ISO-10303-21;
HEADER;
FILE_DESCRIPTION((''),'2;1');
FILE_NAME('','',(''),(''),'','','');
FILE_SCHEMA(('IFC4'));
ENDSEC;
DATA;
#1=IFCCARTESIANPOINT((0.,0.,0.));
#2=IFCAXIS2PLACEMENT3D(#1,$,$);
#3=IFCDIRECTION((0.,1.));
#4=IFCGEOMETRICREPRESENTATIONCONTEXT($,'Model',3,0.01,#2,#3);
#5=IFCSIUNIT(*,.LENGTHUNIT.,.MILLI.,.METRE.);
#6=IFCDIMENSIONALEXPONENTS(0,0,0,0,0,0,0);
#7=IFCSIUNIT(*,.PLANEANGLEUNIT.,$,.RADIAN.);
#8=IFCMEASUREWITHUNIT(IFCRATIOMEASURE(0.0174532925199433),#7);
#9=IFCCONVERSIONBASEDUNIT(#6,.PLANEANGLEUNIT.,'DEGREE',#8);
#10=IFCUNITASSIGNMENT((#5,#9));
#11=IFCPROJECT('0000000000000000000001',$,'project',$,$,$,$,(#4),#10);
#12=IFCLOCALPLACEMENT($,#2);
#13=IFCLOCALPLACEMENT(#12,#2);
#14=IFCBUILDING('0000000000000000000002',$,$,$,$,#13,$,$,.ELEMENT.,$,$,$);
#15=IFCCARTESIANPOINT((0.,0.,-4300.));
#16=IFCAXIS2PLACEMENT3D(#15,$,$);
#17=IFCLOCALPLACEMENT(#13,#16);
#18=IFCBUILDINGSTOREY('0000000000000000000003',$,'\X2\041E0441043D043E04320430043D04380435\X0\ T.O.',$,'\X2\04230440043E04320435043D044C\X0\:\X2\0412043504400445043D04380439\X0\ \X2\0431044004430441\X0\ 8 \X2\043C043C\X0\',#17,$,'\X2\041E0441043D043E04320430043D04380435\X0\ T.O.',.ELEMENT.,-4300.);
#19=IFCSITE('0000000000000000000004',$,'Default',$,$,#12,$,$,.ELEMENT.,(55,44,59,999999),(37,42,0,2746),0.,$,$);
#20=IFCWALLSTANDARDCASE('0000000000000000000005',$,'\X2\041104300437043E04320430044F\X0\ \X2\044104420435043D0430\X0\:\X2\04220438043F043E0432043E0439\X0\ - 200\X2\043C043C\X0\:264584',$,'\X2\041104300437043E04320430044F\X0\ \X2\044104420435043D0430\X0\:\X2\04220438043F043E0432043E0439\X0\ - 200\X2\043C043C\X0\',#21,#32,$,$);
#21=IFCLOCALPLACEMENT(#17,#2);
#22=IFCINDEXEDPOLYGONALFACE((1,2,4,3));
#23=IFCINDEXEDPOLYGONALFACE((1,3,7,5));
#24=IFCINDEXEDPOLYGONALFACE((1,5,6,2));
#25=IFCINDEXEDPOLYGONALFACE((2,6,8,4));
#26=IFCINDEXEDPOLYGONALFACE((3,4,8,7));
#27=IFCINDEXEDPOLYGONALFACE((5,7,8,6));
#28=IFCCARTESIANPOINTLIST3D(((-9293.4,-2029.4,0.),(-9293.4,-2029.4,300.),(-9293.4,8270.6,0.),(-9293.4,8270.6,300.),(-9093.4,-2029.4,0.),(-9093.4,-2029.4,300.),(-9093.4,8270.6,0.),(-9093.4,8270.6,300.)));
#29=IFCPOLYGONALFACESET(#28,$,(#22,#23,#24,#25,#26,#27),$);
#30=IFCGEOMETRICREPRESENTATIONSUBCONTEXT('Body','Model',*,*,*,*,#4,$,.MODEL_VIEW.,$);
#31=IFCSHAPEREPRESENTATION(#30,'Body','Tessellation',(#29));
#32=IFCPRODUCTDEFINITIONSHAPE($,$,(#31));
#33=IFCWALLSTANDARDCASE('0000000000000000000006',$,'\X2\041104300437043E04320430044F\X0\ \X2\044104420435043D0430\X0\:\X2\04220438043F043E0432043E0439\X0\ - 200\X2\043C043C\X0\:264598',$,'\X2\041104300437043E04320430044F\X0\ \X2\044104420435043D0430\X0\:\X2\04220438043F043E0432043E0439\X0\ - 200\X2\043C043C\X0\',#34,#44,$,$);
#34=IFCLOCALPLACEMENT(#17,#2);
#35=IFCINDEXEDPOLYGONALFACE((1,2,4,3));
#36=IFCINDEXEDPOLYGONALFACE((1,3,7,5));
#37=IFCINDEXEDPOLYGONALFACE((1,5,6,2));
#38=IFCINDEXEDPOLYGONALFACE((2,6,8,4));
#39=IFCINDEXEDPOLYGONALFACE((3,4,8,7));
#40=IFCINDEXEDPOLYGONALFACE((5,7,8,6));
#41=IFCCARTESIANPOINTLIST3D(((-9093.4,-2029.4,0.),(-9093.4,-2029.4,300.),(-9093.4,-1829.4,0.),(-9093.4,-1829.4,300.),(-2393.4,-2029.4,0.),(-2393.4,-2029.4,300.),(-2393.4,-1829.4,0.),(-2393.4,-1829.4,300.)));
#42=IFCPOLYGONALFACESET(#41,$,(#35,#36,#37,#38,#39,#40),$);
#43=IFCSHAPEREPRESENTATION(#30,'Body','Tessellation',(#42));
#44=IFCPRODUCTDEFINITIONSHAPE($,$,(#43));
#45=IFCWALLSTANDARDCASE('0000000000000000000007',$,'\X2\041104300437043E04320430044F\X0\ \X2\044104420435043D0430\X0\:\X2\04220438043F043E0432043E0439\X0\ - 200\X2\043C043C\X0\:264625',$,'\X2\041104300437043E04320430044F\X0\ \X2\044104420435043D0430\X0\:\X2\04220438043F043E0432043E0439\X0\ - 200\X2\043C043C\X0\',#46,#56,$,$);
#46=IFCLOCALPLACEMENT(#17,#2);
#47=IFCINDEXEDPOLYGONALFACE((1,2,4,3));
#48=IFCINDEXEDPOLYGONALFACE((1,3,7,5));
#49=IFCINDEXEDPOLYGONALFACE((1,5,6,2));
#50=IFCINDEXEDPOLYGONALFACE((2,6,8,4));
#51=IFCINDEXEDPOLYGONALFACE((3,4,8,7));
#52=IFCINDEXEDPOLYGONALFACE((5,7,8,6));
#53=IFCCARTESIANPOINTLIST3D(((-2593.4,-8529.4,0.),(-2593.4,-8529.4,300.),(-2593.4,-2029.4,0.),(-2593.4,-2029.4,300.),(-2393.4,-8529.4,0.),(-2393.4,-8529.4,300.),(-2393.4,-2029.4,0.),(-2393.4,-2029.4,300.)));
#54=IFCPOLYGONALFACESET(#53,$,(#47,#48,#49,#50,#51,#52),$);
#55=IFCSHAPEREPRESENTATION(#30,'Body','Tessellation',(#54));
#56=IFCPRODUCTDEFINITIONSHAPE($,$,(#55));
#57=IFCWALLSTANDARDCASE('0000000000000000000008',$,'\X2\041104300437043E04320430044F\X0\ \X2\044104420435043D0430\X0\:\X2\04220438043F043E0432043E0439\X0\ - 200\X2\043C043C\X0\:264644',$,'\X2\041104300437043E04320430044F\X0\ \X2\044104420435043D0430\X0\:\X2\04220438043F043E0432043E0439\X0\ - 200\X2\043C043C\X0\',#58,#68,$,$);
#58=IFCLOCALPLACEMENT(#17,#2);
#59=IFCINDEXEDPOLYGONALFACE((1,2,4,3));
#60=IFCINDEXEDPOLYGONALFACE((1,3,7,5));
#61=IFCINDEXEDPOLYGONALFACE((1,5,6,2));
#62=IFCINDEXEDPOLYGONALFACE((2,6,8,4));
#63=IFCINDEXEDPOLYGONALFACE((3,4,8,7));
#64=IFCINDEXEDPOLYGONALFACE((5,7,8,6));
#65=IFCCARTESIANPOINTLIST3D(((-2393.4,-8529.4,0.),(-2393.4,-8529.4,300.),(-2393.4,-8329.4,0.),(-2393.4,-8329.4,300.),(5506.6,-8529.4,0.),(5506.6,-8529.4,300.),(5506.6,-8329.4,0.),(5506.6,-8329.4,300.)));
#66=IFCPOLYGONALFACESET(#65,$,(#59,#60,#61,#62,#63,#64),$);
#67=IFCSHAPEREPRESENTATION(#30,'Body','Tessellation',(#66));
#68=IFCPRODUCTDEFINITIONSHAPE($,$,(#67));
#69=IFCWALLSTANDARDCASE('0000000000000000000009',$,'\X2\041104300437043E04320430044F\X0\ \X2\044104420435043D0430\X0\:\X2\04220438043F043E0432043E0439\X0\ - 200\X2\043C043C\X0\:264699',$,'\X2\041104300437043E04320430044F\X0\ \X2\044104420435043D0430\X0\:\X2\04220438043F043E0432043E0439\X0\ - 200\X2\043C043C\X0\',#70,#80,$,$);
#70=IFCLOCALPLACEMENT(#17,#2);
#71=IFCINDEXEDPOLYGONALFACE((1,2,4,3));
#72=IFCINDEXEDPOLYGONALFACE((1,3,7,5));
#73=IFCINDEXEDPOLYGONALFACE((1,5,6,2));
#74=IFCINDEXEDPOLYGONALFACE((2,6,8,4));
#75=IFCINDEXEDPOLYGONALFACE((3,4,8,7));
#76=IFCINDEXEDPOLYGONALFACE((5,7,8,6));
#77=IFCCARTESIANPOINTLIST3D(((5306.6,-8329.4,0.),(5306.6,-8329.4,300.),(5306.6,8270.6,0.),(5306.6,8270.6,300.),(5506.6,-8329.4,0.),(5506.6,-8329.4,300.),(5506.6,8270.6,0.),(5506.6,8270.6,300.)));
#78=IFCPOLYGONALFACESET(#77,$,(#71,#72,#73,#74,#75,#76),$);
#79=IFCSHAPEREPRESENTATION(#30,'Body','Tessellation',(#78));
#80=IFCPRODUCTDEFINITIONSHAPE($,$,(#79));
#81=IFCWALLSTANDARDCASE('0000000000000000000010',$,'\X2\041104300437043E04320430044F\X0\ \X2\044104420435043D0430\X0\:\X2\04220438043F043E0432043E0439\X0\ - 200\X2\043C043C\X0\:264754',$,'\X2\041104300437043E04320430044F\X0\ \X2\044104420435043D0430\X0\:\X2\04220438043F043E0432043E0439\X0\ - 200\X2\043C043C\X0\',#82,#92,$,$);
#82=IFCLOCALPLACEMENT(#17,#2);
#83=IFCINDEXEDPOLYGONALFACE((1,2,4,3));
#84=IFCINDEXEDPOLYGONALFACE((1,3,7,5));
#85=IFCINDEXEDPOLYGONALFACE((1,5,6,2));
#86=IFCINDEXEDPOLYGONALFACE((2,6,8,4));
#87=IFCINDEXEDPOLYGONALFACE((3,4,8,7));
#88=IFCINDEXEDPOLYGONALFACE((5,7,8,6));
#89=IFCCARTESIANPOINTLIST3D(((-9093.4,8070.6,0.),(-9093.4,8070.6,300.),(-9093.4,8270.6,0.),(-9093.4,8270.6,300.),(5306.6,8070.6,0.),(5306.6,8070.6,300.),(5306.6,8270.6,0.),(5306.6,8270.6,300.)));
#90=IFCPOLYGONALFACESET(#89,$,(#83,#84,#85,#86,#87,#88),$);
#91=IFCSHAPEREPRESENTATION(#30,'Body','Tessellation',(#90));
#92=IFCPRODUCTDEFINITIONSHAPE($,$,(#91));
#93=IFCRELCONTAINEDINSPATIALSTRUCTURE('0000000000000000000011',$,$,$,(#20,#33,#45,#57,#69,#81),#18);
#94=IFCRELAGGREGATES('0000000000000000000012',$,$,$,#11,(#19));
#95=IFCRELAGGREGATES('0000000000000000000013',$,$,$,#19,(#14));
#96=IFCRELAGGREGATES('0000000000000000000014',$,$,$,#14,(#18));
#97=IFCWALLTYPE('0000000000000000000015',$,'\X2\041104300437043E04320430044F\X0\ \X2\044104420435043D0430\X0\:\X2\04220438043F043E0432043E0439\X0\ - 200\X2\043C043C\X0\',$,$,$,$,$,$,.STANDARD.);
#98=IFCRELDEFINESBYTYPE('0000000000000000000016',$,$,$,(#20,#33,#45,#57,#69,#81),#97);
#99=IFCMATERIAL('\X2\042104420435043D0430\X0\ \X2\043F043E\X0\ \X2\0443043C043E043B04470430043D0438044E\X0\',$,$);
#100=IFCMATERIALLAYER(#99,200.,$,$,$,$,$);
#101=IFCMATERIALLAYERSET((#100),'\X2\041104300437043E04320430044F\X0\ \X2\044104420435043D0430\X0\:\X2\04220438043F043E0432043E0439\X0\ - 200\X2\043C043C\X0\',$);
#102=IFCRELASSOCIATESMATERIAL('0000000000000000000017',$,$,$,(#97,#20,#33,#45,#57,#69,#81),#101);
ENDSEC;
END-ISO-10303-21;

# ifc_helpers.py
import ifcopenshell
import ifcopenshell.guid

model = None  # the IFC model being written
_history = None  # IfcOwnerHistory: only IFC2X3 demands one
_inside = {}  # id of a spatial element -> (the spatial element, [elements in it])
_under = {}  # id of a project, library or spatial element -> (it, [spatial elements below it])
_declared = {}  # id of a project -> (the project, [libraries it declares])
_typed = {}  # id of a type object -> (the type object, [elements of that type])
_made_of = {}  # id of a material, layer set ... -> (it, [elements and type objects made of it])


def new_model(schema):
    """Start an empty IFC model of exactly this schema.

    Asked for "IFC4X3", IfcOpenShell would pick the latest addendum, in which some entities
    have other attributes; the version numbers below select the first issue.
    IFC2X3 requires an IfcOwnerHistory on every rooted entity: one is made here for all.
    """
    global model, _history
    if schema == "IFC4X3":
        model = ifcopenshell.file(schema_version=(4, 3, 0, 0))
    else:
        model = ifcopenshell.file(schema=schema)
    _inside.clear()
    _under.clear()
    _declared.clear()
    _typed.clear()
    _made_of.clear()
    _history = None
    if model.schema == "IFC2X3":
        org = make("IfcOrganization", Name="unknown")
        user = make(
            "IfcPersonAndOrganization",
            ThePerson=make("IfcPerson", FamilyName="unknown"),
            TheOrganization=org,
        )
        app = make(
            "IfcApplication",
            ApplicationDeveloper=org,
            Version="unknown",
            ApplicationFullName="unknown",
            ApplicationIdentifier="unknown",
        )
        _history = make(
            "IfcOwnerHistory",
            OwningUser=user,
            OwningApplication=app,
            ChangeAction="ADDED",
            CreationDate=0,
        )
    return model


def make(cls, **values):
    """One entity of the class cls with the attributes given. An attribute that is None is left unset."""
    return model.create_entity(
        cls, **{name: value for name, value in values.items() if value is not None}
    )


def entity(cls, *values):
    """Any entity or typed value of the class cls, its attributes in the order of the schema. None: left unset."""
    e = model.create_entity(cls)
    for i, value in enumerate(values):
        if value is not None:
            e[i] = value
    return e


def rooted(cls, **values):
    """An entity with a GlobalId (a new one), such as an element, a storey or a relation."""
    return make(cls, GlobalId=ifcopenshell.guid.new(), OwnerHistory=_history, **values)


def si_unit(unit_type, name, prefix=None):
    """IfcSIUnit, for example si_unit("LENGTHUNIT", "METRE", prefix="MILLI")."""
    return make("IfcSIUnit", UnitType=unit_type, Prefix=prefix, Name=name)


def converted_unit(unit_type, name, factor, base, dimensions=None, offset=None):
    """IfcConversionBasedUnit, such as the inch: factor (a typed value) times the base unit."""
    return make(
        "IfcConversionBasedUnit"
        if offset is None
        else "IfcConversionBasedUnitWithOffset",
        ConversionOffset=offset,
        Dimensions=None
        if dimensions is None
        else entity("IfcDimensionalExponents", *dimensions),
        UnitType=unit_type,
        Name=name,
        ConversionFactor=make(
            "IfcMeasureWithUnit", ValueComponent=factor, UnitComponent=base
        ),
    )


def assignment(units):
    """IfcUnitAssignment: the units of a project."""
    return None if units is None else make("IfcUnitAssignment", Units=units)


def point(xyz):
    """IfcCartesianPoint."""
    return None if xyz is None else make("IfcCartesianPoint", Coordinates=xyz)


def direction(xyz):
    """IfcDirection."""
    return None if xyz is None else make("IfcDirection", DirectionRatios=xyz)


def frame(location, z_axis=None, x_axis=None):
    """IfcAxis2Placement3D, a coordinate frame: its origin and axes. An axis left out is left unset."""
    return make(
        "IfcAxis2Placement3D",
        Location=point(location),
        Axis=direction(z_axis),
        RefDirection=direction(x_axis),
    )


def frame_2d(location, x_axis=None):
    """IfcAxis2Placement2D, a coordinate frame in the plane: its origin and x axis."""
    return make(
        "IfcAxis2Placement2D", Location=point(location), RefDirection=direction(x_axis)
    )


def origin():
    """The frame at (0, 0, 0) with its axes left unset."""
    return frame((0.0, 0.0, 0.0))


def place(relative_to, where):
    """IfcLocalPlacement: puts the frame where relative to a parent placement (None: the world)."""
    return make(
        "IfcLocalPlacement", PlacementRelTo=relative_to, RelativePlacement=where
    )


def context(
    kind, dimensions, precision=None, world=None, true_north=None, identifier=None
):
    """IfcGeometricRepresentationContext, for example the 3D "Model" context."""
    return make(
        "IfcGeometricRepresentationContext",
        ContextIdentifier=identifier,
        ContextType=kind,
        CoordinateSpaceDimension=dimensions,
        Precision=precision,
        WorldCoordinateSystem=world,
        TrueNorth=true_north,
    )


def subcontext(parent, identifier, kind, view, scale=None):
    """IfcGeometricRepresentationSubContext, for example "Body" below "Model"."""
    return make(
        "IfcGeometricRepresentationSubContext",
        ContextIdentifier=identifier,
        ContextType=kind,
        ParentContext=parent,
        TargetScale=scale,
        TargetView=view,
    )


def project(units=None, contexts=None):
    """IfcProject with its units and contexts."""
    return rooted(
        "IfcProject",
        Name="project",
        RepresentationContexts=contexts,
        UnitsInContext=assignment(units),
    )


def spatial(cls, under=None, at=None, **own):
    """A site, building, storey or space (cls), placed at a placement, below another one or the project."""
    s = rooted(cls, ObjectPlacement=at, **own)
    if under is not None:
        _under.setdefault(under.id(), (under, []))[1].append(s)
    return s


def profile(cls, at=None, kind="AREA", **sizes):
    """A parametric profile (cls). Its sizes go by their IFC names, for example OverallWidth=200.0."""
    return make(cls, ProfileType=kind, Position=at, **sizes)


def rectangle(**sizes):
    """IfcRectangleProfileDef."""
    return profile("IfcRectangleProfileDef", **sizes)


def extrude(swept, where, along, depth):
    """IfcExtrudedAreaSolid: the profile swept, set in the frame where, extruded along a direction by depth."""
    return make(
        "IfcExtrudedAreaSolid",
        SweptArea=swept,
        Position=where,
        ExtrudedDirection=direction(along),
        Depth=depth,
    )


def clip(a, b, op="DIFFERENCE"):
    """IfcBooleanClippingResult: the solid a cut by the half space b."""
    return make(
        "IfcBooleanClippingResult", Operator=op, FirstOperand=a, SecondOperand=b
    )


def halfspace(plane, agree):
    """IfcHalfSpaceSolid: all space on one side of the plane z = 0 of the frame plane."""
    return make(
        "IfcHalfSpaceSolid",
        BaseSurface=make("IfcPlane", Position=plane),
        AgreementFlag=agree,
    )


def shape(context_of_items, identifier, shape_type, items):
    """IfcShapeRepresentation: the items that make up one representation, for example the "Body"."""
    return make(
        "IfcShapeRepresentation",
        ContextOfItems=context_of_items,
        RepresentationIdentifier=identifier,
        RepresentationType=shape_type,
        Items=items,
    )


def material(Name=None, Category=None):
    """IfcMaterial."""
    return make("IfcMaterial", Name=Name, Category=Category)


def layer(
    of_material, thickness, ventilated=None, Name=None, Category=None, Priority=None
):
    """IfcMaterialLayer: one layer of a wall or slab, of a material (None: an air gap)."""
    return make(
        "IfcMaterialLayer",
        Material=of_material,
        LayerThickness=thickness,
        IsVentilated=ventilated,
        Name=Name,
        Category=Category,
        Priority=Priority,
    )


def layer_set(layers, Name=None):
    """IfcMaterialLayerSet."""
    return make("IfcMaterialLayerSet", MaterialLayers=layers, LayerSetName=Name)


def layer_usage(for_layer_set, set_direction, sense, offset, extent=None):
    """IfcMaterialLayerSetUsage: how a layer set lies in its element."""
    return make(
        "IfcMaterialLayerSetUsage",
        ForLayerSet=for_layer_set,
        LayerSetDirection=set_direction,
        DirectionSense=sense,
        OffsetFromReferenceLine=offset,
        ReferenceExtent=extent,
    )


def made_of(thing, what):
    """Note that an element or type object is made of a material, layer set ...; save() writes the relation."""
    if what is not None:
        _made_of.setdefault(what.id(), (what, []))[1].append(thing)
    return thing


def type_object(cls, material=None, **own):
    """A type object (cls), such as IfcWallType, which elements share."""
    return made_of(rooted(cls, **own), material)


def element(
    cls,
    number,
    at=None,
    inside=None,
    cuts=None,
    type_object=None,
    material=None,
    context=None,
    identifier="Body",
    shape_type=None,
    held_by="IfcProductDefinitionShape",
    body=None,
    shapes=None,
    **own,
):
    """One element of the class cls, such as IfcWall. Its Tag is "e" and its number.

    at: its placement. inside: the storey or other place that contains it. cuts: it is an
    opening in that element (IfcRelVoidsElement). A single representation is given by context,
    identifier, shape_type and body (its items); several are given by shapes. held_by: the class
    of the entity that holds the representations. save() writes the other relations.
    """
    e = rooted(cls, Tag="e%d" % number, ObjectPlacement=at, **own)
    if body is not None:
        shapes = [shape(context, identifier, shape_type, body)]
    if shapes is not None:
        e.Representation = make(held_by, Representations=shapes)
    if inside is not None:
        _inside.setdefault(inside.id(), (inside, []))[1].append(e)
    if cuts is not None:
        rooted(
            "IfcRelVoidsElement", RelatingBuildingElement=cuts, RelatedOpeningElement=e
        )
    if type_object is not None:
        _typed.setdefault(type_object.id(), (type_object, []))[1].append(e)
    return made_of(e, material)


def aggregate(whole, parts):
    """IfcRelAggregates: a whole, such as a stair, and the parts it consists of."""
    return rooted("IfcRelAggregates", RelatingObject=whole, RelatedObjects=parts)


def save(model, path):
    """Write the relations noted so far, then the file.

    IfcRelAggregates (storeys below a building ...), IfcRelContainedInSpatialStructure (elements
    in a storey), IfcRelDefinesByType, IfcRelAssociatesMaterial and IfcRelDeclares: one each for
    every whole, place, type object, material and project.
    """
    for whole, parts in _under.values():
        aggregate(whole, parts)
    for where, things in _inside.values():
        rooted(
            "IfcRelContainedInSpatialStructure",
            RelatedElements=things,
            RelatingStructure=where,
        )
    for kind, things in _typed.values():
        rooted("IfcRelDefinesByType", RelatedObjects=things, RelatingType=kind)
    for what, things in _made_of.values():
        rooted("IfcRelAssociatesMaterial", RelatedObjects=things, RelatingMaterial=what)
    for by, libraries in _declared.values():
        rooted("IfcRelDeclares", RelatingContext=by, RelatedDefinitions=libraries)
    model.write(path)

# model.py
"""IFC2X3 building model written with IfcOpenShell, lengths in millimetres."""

from ifc_helpers import new_model, entity, si_unit, converted_unit, direction, frame, frame_2d, origin, place, context, subcontext, project, spatial, rectangle, extrude, clip, halfspace, material, layer, layer_set, layer_usage, type_object, element, save


model = new_model("IFC2X3")

# Units and contexts
model_context = context("Model", 3, precision=0.01, world=origin(), true_north=direction((0.0, 1.0)))
body_context = subcontext(model_context, "Body", "Model", "MODEL_VIEW")
ifc_project = project(units=[si_unit("LENGTHUNIT", "METRE", prefix="MILLI"), converted_unit("PLANEANGLEUNIT", "DEGREE", entity("IfcRatioMeasure", 0.0174532925199433), si_unit("PLANEANGLEUNIT", "RADIAN"), dimensions=[0, 0, 0, 0, 0, 0, 0])], contexts=[model_context])

# Site, building, storey
site_placement = place(None, origin())
site = spatial("IfcSite", under=ifc_project, at=site_placement, Name="Default", CompositionType="ELEMENT", RefLatitude=(55, 44, 59, 999999), RefLongitude=(37, 42, 0, 2746), RefElevation=0.0)
building_placement = place(site_placement, origin())
building = spatial("IfcBuilding", under=site, at=building_placement, CompositionType="ELEMENT")
storey_placement = place(building_placement, frame((0.0, 0.0, -4300.0)))
storey = spatial("IfcBuildingStorey", under=building, at=storey_placement, Name="Основание T.O.", ObjectType="Уровень:Верхний брус 8 мм", LongName="Основание T.O.", CompositionType="ELEMENT", Elevation=-4300.0)

# Walls
ifc_material = material(Name="Стена по умолчанию")
ifc_layer = layer(ifc_material, 200.0)
ifc_layer_set = layer_set([ifc_layer], Name="Базовая стена:Типовой - 200мм")
ifc_layer_usage_1 = layer_usage(ifc_layer_set, "AXIS2", "NEGATIVE", 100.0)
wall_type = type_object("IfcWallType", Name="Базовая стена:Типовой - 200мм", PredefinedType="STANDARD", material=ifc_layer_set)
wall_1_placement = place(storey_placement, frame((-9193.4, 8270.6, 0.0), z_axis=(0.0, 0.0, 1.0), x_axis=(0.0, -1.0, 0.0)))
element("IfcWallStandardCase", 1, at=wall_1_placement, inside=storey, type_object=wall_type, material=ifc_layer_usage_1, Name="Базовая стена:Типовой - 200мм:264584", ObjectType="Базовая стена:Типовой - 200мм", context=body_context, shape_type="Clipping", body=[
    clip(extrude(rectangle(XDim=10300.0, YDim=200.0, at=frame_2d((5150.0, 0.0), x_axis=(-1.0, 0.0))), origin(), (0.0, 0.0, 1.0), 300.0), halfspace(frame((0.0, 0.0, -300.0)), True)),
])
ifc_layer_usage_2 = layer_usage(ifc_layer_set, "AXIS2", "NEGATIVE", 100.0)
wall_2_placement = place(storey_placement, frame((-9093.4, -1929.4, 0.0)))
element("IfcWallStandardCase", 2, at=wall_2_placement, inside=storey, type_object=wall_type, material=ifc_layer_usage_2, Name="Базовая стена:Типовой - 200мм:264598", ObjectType="Базовая стена:Типовой - 200мм", context=body_context, shape_type="Clipping", body=[
    clip(extrude(rectangle(XDim=6700.0, YDim=200.0, at=frame_2d((3350.0, 0.0), x_axis=(-1.0, 0.0))), origin(), (0.0, 0.0, 1.0), 300.0), halfspace(frame((0.0, 0.0, -300.0)), True)),
])
ifc_layer_usage_3 = layer_usage(ifc_layer_set, "AXIS2", "NEGATIVE", 100.0)
wall_3_placement = place(storey_placement, frame((-2493.4, -2029.4, 0.0), z_axis=(0.0, 0.0, 1.0), x_axis=(0.0, -1.0, 0.0)))
element("IfcWallStandardCase", 3, at=wall_3_placement, inside=storey, type_object=wall_type, material=ifc_layer_usage_3, Name="Базовая стена:Типовой - 200мм:264625", ObjectType="Базовая стена:Типовой - 200мм", context=body_context, shape_type="Clipping", body=[
    clip(extrude(rectangle(XDim=6500.0, YDim=200.0, at=frame_2d((3250.0, 0.0), x_axis=(-1.0, 0.0))), origin(), (0.0, 0.0, 1.0), 300.0), halfspace(frame((0.0, 0.0, -300.0)), True)),
])
ifc_layer_usage_4 = layer_usage(ifc_layer_set, "AXIS2", "NEGATIVE", 100.0)
wall_4_placement = place(storey_placement, frame((-2393.4, -8429.4, 0.0)))
element("IfcWallStandardCase", 4, at=wall_4_placement, inside=storey, type_object=wall_type, material=ifc_layer_usage_4, Name="Базовая стена:Типовой - 200мм:264644", ObjectType="Базовая стена:Типовой - 200мм", context=body_context, shape_type="Clipping", body=[
    clip(extrude(rectangle(XDim=7900.0, YDim=200.0, at=frame_2d((3950.0, 0.0), x_axis=(-1.0, 0.0))), origin(), (0.0, 0.0, 1.0), 300.0), halfspace(frame((0.0, 0.0, -300.0)), True)),
])
ifc_layer_usage_5 = layer_usage(ifc_layer_set, "AXIS2", "NEGATIVE", 100.0)
wall_5_placement = place(storey_placement, frame((5406.6, -8329.4, 0.0), z_axis=(0.0, 0.0, 1.0), x_axis=(0.0, 1.0, 0.0)))
element("IfcWallStandardCase", 5, at=wall_5_placement, inside=storey, type_object=wall_type, material=ifc_layer_usage_5, Name="Базовая стена:Типовой - 200мм:264699", ObjectType="Базовая стена:Типовой - 200мм", context=body_context, shape_type="Clipping", body=[
    clip(extrude(rectangle(XDim=16600.0, YDim=200.0, at=frame_2d((8300.0, 0.0), x_axis=(-1.0, 0.0))), origin(), (0.0, 0.0, 1.0), 300.0), halfspace(frame((0.0, 0.0, -300.0)), True)),
])
ifc_layer_usage_6 = layer_usage(ifc_layer_set, "AXIS2", "NEGATIVE", 100.0)
wall_6_placement = place(storey_placement, frame((5306.6, 8170.6, 0.0), z_axis=(0.0, 0.0, 1.0), x_axis=(-1.0, 0.0, 0.0)))
element("IfcWallStandardCase", 6, at=wall_6_placement, inside=storey, type_object=wall_type, material=ifc_layer_usage_6, Name="Базовая стена:Типовой - 200мм:264754", ObjectType="Базовая стена:Типовой - 200мм", context=body_context, shape_type="Clipping", body=[
    clip(extrude(rectangle(XDim=14400.0, YDim=200.0, at=frame_2d((7200.0, 0.0), x_axis=(-1.0, 0.0))), origin(), (0.0, 0.0, 1.0), 300.0), halfspace(frame((0.0, 0.0, -300.0)), True)),
])

save(model, "model.ifc")
